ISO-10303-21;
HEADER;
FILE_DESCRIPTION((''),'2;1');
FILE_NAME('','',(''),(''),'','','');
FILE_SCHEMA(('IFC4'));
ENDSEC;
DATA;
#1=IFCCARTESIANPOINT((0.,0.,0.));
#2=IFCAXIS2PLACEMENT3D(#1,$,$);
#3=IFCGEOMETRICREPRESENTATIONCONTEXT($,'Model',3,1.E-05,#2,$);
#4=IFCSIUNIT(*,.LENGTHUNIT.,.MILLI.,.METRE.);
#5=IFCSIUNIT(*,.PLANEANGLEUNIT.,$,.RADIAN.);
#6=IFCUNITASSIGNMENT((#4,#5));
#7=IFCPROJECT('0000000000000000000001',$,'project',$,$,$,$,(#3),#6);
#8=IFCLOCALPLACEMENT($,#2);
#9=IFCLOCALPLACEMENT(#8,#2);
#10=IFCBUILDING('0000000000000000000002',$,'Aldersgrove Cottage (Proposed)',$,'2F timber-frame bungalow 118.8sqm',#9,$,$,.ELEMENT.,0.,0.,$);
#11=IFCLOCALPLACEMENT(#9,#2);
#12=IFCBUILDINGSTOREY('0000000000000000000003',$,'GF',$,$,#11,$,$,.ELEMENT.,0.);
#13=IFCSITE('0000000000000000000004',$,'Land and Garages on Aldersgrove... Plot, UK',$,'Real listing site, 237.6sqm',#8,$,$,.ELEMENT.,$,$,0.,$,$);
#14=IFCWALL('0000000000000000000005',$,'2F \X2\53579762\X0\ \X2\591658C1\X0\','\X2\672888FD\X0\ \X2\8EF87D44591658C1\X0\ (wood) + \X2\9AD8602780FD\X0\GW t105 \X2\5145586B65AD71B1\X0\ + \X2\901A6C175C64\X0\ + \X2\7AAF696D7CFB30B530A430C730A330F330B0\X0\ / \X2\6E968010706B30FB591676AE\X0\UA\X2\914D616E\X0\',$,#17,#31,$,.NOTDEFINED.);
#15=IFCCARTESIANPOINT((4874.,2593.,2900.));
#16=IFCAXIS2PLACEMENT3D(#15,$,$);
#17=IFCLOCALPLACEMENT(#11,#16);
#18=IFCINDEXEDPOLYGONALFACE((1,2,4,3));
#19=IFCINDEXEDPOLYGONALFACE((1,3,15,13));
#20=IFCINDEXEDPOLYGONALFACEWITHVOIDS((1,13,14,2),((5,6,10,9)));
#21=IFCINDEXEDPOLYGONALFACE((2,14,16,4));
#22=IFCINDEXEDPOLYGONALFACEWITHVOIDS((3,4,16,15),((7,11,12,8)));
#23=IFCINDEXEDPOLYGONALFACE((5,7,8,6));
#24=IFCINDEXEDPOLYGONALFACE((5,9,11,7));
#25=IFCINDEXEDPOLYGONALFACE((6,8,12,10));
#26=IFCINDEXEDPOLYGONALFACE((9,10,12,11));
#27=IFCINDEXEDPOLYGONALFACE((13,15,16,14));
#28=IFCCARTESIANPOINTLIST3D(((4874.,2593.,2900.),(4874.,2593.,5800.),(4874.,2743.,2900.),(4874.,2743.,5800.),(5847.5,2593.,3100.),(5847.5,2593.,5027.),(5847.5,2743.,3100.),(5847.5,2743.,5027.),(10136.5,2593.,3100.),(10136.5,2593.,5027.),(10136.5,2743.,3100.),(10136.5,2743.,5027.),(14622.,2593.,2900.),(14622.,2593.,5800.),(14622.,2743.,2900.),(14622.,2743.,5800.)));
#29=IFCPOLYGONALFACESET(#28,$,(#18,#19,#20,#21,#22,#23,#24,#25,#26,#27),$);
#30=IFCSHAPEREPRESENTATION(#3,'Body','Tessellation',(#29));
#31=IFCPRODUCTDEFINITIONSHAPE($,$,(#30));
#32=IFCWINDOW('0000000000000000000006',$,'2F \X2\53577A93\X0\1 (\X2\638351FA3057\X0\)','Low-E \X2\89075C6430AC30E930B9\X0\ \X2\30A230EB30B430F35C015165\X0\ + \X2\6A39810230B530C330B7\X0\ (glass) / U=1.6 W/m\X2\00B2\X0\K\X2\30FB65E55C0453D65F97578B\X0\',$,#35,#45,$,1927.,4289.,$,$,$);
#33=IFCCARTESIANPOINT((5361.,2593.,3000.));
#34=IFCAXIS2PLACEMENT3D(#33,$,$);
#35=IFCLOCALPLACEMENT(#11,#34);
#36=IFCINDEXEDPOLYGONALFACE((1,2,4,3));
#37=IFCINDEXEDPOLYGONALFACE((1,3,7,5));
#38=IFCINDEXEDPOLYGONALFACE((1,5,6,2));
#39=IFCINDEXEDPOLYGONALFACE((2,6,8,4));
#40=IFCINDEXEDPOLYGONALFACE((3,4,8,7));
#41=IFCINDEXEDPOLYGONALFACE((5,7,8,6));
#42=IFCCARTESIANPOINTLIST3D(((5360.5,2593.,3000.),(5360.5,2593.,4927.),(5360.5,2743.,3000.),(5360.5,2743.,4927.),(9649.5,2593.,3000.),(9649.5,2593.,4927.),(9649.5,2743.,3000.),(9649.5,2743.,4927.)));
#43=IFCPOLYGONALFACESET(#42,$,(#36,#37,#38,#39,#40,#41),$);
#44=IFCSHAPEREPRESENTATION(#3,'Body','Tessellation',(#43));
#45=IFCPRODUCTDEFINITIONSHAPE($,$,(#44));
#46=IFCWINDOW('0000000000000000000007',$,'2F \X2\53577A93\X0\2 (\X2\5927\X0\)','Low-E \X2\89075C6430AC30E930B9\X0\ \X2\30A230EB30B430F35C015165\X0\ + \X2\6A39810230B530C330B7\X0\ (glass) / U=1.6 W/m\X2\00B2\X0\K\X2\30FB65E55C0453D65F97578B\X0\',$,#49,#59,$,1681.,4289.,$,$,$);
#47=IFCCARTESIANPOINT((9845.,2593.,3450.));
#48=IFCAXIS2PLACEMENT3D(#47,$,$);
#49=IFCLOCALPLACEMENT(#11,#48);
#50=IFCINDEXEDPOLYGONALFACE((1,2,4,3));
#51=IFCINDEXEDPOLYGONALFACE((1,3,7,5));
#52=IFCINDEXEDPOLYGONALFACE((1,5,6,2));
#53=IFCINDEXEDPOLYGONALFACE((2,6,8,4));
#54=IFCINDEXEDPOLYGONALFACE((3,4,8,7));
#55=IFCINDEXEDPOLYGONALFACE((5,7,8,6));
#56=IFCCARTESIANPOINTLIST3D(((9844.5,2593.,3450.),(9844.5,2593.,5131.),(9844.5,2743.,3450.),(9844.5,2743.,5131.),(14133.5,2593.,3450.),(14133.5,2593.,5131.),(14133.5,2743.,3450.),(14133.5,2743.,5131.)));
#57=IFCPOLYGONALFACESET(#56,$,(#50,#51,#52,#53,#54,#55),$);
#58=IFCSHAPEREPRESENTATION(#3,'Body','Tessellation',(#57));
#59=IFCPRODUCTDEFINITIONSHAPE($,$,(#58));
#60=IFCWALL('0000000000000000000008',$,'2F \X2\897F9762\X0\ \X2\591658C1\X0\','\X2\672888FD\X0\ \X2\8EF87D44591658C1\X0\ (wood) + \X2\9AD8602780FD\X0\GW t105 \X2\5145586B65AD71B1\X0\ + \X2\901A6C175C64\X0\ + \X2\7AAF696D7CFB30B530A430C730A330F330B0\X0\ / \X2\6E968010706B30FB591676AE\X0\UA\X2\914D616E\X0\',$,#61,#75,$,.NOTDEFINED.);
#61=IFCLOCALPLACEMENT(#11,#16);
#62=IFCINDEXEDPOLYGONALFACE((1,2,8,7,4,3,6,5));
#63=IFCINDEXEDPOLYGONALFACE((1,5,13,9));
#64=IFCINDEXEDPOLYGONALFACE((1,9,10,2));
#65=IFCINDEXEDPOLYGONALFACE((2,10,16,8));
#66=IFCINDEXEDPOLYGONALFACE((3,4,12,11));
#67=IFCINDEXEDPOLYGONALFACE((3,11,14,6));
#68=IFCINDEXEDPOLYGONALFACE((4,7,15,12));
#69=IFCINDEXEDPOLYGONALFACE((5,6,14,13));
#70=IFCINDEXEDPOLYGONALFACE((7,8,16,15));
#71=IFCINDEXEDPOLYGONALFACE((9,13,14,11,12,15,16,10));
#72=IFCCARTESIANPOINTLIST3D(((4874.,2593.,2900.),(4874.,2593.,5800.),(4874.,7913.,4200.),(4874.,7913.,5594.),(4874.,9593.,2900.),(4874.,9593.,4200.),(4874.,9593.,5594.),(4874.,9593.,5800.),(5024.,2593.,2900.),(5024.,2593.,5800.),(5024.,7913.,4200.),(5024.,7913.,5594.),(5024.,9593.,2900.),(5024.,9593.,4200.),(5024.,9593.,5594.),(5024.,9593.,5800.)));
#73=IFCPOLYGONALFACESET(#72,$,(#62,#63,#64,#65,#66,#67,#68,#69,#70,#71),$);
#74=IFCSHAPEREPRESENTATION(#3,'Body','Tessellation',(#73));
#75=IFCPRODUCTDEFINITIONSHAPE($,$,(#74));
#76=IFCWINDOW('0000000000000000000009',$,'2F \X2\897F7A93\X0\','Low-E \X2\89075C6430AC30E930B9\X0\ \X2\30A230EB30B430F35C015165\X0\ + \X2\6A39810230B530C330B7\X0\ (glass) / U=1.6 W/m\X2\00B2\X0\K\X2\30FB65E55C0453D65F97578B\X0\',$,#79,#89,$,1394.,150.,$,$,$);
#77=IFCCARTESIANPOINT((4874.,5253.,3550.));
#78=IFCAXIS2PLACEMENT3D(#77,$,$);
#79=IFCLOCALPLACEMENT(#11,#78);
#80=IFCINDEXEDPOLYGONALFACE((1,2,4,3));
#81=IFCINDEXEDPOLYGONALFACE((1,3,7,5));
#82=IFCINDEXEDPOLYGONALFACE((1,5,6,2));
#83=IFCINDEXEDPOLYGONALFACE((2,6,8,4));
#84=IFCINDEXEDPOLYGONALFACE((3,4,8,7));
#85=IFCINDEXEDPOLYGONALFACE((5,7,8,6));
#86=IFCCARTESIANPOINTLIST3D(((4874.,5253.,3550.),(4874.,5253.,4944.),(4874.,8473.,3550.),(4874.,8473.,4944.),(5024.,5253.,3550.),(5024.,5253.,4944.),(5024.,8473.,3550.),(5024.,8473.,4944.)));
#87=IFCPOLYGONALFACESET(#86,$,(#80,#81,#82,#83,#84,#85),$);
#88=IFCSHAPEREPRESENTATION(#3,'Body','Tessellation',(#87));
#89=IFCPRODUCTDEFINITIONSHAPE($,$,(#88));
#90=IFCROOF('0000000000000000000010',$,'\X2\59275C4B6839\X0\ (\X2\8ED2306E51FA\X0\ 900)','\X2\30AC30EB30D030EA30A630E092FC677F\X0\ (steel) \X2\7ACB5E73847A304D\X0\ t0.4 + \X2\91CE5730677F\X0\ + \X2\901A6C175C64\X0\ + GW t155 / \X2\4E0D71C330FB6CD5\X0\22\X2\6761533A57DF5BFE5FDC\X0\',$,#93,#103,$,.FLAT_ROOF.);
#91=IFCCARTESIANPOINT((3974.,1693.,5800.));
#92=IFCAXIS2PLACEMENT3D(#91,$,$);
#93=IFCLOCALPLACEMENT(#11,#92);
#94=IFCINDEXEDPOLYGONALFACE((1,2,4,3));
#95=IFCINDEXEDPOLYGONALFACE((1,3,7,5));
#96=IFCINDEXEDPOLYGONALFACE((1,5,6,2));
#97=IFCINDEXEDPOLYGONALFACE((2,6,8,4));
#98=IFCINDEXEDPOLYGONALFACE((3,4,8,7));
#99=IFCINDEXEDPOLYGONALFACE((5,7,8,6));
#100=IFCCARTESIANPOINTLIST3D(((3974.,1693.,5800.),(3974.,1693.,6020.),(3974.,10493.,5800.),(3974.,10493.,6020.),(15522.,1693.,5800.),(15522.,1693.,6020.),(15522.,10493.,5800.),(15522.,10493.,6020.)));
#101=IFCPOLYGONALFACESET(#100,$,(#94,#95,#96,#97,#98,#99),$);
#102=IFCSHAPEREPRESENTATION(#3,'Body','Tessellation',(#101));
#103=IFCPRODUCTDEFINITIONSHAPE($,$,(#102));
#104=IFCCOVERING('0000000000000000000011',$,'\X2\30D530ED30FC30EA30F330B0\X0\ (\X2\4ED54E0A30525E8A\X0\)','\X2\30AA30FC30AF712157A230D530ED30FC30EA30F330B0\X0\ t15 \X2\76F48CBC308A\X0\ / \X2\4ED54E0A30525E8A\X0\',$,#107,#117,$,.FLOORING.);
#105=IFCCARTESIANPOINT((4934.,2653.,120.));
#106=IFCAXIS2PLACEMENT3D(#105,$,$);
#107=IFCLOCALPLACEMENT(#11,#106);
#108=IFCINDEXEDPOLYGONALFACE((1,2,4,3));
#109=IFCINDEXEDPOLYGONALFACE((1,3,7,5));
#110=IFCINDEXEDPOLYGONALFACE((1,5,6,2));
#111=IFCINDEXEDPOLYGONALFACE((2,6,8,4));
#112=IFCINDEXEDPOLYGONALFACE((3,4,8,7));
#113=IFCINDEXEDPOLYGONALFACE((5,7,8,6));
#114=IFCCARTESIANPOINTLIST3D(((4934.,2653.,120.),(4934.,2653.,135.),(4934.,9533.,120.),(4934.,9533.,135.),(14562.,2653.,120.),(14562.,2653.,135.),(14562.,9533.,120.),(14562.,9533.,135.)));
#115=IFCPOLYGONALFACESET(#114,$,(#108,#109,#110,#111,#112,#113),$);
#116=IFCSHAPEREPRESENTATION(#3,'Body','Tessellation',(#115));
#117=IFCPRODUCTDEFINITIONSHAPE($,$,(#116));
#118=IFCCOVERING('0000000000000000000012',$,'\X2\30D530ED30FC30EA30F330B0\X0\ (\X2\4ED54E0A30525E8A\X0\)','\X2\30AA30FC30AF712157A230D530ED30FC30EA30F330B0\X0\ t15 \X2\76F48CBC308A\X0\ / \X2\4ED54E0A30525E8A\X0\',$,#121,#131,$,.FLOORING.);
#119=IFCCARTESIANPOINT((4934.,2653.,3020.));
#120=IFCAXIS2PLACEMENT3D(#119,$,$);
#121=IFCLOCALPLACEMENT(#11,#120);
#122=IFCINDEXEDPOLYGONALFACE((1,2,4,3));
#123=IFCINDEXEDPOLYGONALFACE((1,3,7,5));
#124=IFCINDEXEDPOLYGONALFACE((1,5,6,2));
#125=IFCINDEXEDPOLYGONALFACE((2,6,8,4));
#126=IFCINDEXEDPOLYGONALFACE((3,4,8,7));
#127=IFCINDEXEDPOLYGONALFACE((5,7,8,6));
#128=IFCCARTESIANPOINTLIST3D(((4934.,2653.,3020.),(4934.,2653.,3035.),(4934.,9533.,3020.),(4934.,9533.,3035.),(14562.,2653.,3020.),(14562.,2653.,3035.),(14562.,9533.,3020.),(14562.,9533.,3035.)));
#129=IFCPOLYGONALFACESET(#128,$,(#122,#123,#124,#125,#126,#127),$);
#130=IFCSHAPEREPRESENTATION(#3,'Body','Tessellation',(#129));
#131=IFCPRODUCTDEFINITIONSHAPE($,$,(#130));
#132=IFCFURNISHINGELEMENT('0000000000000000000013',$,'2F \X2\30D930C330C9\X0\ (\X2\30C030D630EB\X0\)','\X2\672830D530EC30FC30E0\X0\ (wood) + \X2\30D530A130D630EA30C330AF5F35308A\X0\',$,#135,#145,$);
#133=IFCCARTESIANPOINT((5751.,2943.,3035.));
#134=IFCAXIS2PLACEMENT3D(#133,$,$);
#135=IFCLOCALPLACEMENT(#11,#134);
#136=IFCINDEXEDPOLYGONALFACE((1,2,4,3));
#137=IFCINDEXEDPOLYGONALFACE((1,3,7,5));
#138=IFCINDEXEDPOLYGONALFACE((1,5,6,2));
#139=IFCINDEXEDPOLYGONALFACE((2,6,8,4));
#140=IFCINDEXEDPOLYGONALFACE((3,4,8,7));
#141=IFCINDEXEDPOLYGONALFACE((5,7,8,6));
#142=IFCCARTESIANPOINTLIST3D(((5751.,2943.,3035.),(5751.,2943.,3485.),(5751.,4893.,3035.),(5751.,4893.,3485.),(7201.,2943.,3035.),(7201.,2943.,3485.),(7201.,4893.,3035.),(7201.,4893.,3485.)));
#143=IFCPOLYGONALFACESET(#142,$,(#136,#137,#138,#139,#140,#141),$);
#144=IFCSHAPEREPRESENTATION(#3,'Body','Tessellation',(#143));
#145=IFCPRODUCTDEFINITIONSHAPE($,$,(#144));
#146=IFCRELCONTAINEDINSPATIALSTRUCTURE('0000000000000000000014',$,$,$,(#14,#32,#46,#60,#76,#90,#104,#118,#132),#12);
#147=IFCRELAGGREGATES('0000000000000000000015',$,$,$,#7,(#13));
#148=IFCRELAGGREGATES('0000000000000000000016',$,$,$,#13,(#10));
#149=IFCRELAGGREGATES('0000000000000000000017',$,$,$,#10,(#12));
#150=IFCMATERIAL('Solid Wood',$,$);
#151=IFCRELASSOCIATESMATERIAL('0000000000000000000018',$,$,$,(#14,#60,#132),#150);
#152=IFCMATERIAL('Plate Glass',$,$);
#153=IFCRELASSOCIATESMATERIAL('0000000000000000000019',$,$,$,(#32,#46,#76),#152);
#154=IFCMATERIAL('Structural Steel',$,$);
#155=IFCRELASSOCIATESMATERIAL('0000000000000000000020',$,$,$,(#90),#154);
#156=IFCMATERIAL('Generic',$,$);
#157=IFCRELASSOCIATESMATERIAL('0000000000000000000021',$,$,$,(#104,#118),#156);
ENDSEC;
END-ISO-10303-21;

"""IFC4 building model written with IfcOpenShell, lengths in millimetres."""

from ifc_helpers import new_model, si_unit, frame, frame_2d, origin, place, context, project, spatial, rectangle, extrude, material, element, fill, save


model = new_model("IFC4")

# Units and contexts
model_context = context("Model", 3, precision=1e-05, world=origin())
ifc_project = project(units=[si_unit("LENGTHUNIT", "METRE", prefix="MILLI"), si_unit("PLANEANGLEUNIT", "RADIAN")], contexts=[model_context])

# Site, building, storey
site_placement = place(None, origin())
site = spatial("IfcSite", under=ifc_project, at=site_placement, Name="Land and Garages on Aldersgrove... Plot, UK", ObjectType="Real listing site, 237.6sqm", CompositionType="ELEMENT", RefElevation=0.0)
building_placement = place(site_placement, origin())
building = spatial("IfcBuilding", under=site, at=building_placement, Name="Aldersgrove Cottage (Proposed)", ObjectType="2F timber-frame bungalow 118.8sqm", CompositionType="ELEMENT", ElevationOfRefHeight=0.0, ElevationOfTerrain=0.0)
storey_placement = place(building_placement, origin())
storey = spatial("IfcBuildingStorey", under=building, at=storey_placement, Name="GF", CompositionType="ELEMENT", Elevation=0.0)

# Shared definitions
ifc_material_1 = material(Name="Solid Wood")

# Shared definitions
ifc_material_2 = material(Name="Plate Glass")

# Wall, openings, windows
wall_1_placement = place(storey_placement, frame((4874.0, 2593.0, 2900.0)))
wall_1 = element("IfcWall", 1, at=wall_1_placement, inside=storey, material=ifc_material_1, Name="2F 南面 外壁", Description="木製 軸組外壁 (wood) + 高性能GW t105 充填断熱 + 通気層 + 窯業系サイディング / 準耐火・外皮UA配慮", PredefinedType="NOTDEFINED", context=model_context, shape_type="SweptSolid", body=[
    extrude(rectangle(XDim=9748.0, YDim=150.0, at=frame_2d((4874.0, 75.0))), frame((4874.0, 2593.0, 2900.0)), (0.0, 0.0, 1.0), 2900.0),
])
opening_1_placement = place(storey_placement, frame((5361.0, 2593.0, 3000.0)))
opening_1 = element("IfcOpeningElement", 2, at=opening_1_placement, cuts=wall_1, PredefinedType="NOTDEFINED", context=model_context, shape_type="SweptSolid", body=[
    extrude(rectangle(XDim=4289.0, YDim=150.0, at=frame_2d((2144.0, 75.0))), frame((5361.0, 2593.0, 3000.0)), (0.0, 0.0, 1.0), 1927.0),
])
opening_2_placement = place(storey_placement, frame((9845.0, 2593.0, 3450.0)))
opening_2 = element("IfcOpeningElement", 3, at=opening_2_placement, cuts=wall_1, PredefinedType="NOTDEFINED", context=model_context, shape_type="SweptSolid", body=[
    extrude(rectangle(XDim=4289.0, YDim=150.0, at=frame_2d((2144.0, 75.0))), frame((9845.0, 2593.0, 3450.0)), (0.0, 0.0, 1.0), 1681.0),
])
window_1_placement = place(storey_placement, frame((5361.0, 2593.0, 3000.0)))
window_1 = element("IfcWindow", 4, at=window_1_placement, inside=storey, material=ifc_material_2, Name="2F 南窓1 (掃出し)", Description="Low-E 複層ガラス アルゴン封入 + 樹脂サッシ (glass) / U=1.6 W/m²K・日射取得型", OverallHeight=1927.0, OverallWidth=4289.0, context=model_context, shape_type="SweptSolid", body=[
    extrude(rectangle(XDim=4289.0, YDim=150.0, at=frame_2d((2144.0, 75.0))), frame((5361.0, 2593.0, 3000.0)), (0.0, 0.0, 1.0), 1927.0),
])
fill(opening_1, window_1)
window_2_placement = place(storey_placement, frame((9845.0, 2593.0, 3450.0)))
window_2 = element("IfcWindow", 5, at=window_2_placement, inside=storey, material=ifc_material_2, Name="2F 南窓2 (大)", Description="Low-E 複層ガラス アルゴン封入 + 樹脂サッシ (glass) / U=1.6 W/m²K・日射取得型", OverallHeight=1681.0, OverallWidth=4289.0, context=model_context, shape_type="SweptSolid", body=[
    extrude(rectangle(XDim=4289.0, YDim=150.0, at=frame_2d((2144.0, 75.0))), frame((9845.0, 2593.0, 3450.0)), (0.0, 0.0, 1.0), 1681.0),
])
fill(opening_2, window_2)

# Wall, opening, window
wall_2_placement = place(storey_placement, frame((4874.0, 2593.0, 2900.0)))
wall_2 = element("IfcWall", 6, at=wall_2_placement, inside=storey, material=ifc_material_1, Name="2F 西面 外壁", Description="木製 軸組外壁 (wood) + 高性能GW t105 充填断熱 + 通気層 + 窯業系サイディング / 準耐火・外皮UA配慮", PredefinedType="NOTDEFINED", context=model_context, shape_type="SweptSolid", body=[
    extrude(rectangle(XDim=150.0, YDim=7000.0, at=frame_2d((75.0, 3500.0))), frame((4874.0, 2593.0, 2900.0)), (0.0, 0.0, 1.0), 2900.0),
])
opening_3_placement = place(storey_placement, frame((4874.0, 5253.0, 3550.0)))
opening_3 = element("IfcOpeningElement", 7, at=opening_3_placement, cuts=wall_2, PredefinedType="NOTDEFINED", context=model_context, shape_type="SweptSolid", body=[
    extrude(rectangle(XDim=150.0, YDim=3220.0, at=frame_2d((75.0, 1610.0))), frame((4874.0, 5253.0, 3550.0)), (0.0, 0.0, 1.0), 1394.0),
])
window_3_placement = place(storey_placement, frame((4874.0, 5253.0, 3550.0)))
window_3 = element("IfcWindow", 8, at=window_3_placement, inside=storey, material=ifc_material_2, Name="2F 西窓", Description="Low-E 複層ガラス アルゴン封入 + 樹脂サッシ (glass) / U=1.6 W/m²K・日射取得型", OverallHeight=1394.0, OverallWidth=150.0, context=model_context, shape_type="SweptSolid", body=[
    extrude(rectangle(XDim=150.0, YDim=3220.0, at=frame_2d((75.0, 1610.0))), frame((4874.0, 5253.0, 3550.0)), (0.0, 0.0, 1.0), 1394.0),
])
fill(opening_3, window_3)

# Roof
ifc_material_3 = material(Name="Structural Steel")
roof_placement = place(storey_placement, frame((3974.0, 1693.0, 5800.0)))
element("IfcRoof", 9, at=roof_placement, inside=storey, material=ifc_material_3, Name="大屋根 (軒の出 900)", Description="ガルバリウム鋼板 (steel) 立平葺き t0.4 + 野地板 + 通気層 + GW t155 / 不燃・法22条区域対応", PredefinedType="FLAT_ROOF", context=model_context, shape_type="SweptSolid", body=[
    extrude(rectangle(XDim=11548.0, YDim=8800.0, at=frame_2d((5774.0, 4400.0))), frame((3974.0, 1693.0, 5800.0)), (0.0, 0.0, 1.0), 220.0),
])

# Coverings
ifc_material_4 = material(Name="Generic")
covering_1_placement = place(storey_placement, frame((4934.0, 2653.0, 120.0)))
element("IfcCovering", 10, at=covering_1_placement, inside=storey, material=ifc_material_4, Name="フローリング (仕上げ床)", Description="オーク無垢フローリング t15 直貼り / 仕上げ床", PredefinedType="FLOORING", context=model_context, shape_type="SweptSolid", body=[
    extrude(rectangle(XDim=9628.0, YDim=6880.0, at=frame_2d((4814.0, 3440.0))), frame((4934.0, 2653.0, 120.0)), (0.0, 0.0, 1.0), 15.0),
])
covering_2_placement = place(storey_placement, frame((4934.0, 2653.0, 3020.0)))
element("IfcCovering", 11, at=covering_2_placement, inside=storey, material=ifc_material_4, Name="フローリング (仕上げ床)", Description="オーク無垢フローリング t15 直貼り / 仕上げ床", PredefinedType="FLOORING", context=model_context, shape_type="SweptSolid", body=[
    extrude(rectangle(XDim=9628.0, YDim=6880.0, at=frame_2d((4814.0, 3440.0))), frame((4934.0, 2653.0, 3020.0)), (0.0, 0.0, 1.0), 15.0),
])

# Furnishing element
furnishing_placement = place(storey_placement, frame((5751.0, 2943.0, 3035.0)))
element("IfcFurnishingElement", 12, at=furnishing_placement, inside=storey, material=ifc_material_1, Name="2F ベッド (ダブル)", Description="木フレーム (wood) + ファブリック張り", context=model_context, shape_type="SweptSolid", body=[
    extrude(rectangle(XDim=1450.0, YDim=1950.0, at=frame_2d((725.0, 975.0))), frame((5751.0, 2943.0, 3035.0)), (0.0, 0.0, 1.0), 450.0),
])

save(model, "model.ifc")
